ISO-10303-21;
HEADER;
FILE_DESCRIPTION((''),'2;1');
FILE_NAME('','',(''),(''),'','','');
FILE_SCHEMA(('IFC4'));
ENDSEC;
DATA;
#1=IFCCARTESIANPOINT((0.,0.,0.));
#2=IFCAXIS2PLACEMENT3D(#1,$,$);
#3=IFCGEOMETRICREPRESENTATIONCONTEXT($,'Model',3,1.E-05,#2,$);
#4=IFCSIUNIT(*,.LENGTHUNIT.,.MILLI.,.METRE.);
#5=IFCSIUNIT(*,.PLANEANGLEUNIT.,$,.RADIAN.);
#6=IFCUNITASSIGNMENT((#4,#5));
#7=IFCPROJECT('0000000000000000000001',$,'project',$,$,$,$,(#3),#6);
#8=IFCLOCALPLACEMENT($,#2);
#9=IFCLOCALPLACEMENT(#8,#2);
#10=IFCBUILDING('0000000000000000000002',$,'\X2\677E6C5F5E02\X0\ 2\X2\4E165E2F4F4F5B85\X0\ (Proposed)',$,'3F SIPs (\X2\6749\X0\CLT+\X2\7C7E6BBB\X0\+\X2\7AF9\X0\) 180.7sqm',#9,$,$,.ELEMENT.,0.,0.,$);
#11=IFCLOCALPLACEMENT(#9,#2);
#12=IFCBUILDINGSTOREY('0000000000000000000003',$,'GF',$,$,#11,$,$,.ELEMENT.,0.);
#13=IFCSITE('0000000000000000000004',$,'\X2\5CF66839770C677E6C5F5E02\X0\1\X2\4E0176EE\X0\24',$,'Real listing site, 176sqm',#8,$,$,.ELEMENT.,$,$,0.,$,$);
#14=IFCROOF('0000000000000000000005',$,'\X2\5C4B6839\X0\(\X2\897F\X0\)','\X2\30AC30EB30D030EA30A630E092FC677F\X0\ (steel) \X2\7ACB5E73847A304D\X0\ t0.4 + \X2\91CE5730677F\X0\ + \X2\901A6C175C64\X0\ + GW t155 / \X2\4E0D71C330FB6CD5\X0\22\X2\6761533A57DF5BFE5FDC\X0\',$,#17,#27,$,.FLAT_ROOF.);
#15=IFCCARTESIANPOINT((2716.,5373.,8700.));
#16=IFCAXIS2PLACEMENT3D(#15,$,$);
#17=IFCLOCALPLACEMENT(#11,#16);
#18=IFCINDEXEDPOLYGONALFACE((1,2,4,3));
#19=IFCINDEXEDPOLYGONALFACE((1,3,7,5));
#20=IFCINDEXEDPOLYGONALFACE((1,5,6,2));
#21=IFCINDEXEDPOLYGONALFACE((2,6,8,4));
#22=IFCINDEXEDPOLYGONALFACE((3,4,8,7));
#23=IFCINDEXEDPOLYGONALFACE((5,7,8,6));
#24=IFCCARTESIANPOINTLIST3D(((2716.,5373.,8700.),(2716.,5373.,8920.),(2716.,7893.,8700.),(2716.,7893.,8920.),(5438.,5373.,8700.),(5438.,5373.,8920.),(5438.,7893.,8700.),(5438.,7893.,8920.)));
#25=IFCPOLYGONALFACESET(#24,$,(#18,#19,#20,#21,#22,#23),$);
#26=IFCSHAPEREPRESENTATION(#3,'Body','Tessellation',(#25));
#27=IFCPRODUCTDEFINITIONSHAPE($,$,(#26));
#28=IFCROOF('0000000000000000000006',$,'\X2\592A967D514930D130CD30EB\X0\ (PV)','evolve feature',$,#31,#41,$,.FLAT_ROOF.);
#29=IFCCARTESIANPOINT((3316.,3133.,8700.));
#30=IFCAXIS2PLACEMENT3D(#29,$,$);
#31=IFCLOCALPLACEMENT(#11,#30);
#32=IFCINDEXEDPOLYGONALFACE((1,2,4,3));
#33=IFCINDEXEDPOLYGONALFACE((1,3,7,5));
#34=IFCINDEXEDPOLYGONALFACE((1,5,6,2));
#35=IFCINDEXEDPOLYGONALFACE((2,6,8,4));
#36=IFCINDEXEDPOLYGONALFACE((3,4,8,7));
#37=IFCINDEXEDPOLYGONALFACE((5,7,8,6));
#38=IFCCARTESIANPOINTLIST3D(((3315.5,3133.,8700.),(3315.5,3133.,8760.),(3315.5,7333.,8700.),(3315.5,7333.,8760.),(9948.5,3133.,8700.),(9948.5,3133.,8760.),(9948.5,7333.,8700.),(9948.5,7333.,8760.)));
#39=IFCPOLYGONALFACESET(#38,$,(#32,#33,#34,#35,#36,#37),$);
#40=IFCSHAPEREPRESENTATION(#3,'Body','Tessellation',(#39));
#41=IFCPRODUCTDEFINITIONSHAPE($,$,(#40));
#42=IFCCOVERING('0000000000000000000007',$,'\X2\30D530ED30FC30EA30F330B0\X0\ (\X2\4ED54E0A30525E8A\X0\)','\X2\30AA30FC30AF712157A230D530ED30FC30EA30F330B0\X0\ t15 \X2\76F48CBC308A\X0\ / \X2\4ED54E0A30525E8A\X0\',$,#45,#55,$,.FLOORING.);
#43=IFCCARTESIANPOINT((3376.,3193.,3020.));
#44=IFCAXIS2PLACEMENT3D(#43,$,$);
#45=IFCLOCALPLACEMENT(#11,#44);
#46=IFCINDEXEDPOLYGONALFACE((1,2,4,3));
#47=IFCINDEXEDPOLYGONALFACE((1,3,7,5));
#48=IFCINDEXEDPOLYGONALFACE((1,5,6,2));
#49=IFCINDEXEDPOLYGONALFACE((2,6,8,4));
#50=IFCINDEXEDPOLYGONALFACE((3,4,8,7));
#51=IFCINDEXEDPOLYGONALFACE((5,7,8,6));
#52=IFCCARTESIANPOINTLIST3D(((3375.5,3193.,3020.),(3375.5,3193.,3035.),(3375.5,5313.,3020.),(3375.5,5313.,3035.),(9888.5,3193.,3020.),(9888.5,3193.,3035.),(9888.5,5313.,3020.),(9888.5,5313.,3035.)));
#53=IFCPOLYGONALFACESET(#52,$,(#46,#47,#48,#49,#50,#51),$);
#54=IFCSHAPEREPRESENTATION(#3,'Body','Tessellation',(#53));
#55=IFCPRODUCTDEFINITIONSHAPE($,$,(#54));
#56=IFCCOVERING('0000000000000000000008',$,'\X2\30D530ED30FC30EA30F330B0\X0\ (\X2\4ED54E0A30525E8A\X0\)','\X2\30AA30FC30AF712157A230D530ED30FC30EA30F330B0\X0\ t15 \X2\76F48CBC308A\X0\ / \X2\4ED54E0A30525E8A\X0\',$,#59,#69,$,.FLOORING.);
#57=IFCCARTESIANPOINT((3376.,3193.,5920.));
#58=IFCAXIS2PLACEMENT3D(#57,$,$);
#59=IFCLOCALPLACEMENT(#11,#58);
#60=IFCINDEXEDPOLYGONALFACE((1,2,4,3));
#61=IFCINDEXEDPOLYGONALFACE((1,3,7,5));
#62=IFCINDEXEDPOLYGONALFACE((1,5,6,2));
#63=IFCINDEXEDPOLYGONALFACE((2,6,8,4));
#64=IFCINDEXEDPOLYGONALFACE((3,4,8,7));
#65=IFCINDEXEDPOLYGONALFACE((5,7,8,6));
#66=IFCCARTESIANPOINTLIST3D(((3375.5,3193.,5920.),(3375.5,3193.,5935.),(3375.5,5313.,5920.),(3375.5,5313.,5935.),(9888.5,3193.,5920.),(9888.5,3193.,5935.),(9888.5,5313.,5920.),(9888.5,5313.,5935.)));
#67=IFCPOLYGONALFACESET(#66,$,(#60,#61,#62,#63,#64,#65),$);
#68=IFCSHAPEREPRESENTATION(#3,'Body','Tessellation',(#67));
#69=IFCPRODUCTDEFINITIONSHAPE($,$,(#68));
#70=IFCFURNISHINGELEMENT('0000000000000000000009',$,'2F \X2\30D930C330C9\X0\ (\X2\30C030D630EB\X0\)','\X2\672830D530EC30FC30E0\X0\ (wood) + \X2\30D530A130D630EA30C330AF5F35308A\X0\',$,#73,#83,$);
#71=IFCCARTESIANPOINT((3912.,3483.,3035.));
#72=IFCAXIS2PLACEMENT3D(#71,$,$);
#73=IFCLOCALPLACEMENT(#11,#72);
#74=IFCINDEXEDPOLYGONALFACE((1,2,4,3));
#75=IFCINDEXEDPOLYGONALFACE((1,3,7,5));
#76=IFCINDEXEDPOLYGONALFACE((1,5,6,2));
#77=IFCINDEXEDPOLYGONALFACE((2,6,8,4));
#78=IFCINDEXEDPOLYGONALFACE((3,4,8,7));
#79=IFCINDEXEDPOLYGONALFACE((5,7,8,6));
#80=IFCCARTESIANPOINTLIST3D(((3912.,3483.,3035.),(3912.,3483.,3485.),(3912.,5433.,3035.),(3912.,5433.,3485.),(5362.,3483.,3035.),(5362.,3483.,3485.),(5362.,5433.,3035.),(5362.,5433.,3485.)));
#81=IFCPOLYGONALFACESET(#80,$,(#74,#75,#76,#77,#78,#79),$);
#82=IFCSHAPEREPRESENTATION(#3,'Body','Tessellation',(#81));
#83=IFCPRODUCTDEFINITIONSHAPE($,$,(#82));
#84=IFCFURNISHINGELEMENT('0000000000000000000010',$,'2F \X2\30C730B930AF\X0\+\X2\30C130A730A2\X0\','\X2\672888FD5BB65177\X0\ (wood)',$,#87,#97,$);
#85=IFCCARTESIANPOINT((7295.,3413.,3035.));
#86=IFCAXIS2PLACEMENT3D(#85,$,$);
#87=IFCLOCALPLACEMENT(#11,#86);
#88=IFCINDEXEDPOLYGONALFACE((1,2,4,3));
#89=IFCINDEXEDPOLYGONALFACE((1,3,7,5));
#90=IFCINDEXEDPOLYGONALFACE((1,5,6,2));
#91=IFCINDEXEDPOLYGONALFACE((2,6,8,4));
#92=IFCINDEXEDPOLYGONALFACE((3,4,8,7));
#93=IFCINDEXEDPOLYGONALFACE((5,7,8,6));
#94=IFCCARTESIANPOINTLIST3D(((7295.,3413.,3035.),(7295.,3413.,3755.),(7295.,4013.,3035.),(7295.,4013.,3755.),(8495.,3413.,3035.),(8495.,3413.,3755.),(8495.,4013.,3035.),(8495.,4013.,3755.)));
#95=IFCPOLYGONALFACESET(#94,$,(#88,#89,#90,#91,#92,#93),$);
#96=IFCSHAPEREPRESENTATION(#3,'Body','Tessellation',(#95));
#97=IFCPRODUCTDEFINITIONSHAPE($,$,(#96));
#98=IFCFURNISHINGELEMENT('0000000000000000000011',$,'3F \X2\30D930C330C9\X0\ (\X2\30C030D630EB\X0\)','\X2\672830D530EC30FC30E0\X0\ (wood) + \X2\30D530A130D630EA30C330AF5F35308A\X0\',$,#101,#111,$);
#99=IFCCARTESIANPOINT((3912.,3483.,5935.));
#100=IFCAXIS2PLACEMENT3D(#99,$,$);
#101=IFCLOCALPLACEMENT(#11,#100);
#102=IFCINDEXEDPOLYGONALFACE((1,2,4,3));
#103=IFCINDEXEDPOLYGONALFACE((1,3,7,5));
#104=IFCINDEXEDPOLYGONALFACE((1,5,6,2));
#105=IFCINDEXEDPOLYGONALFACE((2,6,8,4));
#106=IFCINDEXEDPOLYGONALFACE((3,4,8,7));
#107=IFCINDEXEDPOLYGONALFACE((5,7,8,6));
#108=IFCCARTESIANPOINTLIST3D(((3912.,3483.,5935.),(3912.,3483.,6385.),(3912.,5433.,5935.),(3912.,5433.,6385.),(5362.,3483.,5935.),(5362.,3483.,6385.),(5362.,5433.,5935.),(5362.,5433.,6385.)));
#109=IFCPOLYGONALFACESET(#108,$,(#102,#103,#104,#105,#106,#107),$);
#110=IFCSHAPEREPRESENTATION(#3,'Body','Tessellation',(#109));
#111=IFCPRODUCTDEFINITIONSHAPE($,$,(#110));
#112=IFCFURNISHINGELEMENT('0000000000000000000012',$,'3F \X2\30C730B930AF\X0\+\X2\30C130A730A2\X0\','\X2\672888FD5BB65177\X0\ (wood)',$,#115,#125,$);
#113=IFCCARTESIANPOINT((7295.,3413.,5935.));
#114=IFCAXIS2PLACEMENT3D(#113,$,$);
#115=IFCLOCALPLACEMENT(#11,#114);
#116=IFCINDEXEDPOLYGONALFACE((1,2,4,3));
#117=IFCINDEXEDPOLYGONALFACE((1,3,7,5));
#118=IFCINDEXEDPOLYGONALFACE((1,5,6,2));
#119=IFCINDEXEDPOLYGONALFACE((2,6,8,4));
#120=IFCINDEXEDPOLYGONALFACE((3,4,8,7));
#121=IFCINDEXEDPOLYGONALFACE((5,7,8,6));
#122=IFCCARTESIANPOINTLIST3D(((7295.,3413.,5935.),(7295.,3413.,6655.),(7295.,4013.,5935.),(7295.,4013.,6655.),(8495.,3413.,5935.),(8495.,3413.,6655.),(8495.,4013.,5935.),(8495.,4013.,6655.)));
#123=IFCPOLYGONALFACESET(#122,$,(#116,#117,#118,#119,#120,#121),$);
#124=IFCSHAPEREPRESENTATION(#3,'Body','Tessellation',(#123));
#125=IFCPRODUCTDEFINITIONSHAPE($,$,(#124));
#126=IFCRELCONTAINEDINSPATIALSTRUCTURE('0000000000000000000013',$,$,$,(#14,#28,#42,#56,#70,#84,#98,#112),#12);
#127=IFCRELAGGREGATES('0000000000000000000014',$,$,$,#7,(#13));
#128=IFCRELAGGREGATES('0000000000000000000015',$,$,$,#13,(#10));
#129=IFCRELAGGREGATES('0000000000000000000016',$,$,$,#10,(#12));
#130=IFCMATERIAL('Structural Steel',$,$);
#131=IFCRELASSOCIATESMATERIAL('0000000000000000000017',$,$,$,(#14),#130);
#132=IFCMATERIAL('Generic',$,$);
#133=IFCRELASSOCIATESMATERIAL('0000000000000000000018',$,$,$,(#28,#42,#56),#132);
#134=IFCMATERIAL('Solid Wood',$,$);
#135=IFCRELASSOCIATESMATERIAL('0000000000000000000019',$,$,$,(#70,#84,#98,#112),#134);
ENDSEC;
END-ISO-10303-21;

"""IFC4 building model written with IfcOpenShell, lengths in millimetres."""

from ifc_helpers import new_model, si_unit, frame, frame_2d, origin, place, context, project, spatial, rectangle, extrude, material, element, save


model = new_model("IFC4")

# Units and contexts
model_context = context("Model", 3, precision=1e-05, world=origin())
ifc_project = project(units=[si_unit("LENGTHUNIT", "METRE", prefix="MILLI"), si_unit("PLANEANGLEUNIT", "RADIAN")], contexts=[model_context])

# Site, building, storey
site_placement = place(None, origin())
site = spatial("IfcSite", under=ifc_project, at=site_placement, Name="島根県松江市1丁目24", ObjectType="Real listing site, 176sqm", CompositionType="ELEMENT", RefElevation=0.0)
building_placement = place(site_placement, origin())
building = spatial("IfcBuilding", under=site, at=building_placement, Name="松江市 2世帯住宅 (Proposed)", ObjectType="3F SIPs (杉CLT+籾殻+竹) 180.7sqm", CompositionType="ELEMENT", ElevationOfRefHeight=0.0, ElevationOfTerrain=0.0)
storey_placement = place(building_placement, origin())
storey = spatial("IfcBuildingStorey", under=building, at=storey_placement, Name="GF", CompositionType="ELEMENT", Elevation=0.0)

# Shared definitions
ifc_material_1 = material(Name="Solid Wood")

# Roofs
ifc_material_2 = material(Name="Structural Steel")
roof_1_placement = place(storey_placement, frame((2716.0, 5373.0, 8700.0)))
element("IfcRoof", 1, at=roof_1_placement, inside=storey, material=ifc_material_2, Name="屋根(西)", Description="ガルバリウム鋼板 (steel) 立平葺き t0.4 + 野地板 + 通気層 + GW t155 / 不燃・法22条区域対応", PredefinedType="FLAT_ROOF", context=model_context, shape_type="SweptSolid", body=[
    extrude(rectangle(XDim=2722.0, YDim=2520.0, at=frame_2d((1361.0, 1260.0))), frame((2716.0, 5373.0, 8700.0)), (0.0, 0.0, 1.0), 220.0),
])
ifc_material_3 = material(Name="Generic")
roof_2_placement = place(storey_placement, frame((3316.0, 3133.0, 8700.0)))
element("IfcRoof", 2, at=roof_2_placement, inside=storey, material=ifc_material_3, Name="太陽光パネル (PV)", Description="evolve feature", PredefinedType="FLAT_ROOF", context=model_context, shape_type="SweptSolid", body=[
    extrude(rectangle(XDim=6633.0, YDim=4200.0, at=frame_2d((3316.0, 2100.0))), frame((3316.0, 3133.0, 8700.0)), (0.0, 0.0, 1.0), 60.0),
])

# Coverings
covering_1_placement = place(storey_placement, frame((3376.0, 3193.0, 3020.0)))
element("IfcCovering", 3, at=covering_1_placement, inside=storey, material=ifc_material_3, Name="フローリング (仕上げ床)", Description="オーク無垢フローリング t15 直貼り / 仕上げ床", PredefinedType="FLOORING", context=model_context, shape_type="SweptSolid", body=[
    extrude(rectangle(XDim=6513.0, YDim=2120.0, at=frame_2d((3256.0, 1060.0))), frame((3376.0, 3193.0, 3020.0)), (0.0, 0.0, 1.0), 15.0),
])
covering_2_placement = place(storey_placement, frame((3376.0, 3193.0, 5920.0)))
element("IfcCovering", 4, at=covering_2_placement, inside=storey, material=ifc_material_3, Name="フローリング (仕上げ床)", Description="オーク無垢フローリング t15 直貼り / 仕上げ床", PredefinedType="FLOORING", context=model_context, shape_type="SweptSolid", body=[
    extrude(rectangle(XDim=6513.0, YDim=2120.0, at=frame_2d((3256.0, 1060.0))), frame((3376.0, 3193.0, 5920.0)), (0.0, 0.0, 1.0), 15.0),
])

# Furnishing elements
furnishing_1_placement = place(storey_placement, frame((3912.0, 3483.0, 3035.0)))
element("IfcFurnishingElement", 5, at=furnishing_1_placement, inside=storey, material=ifc_material_1, Name="2F ベッド (ダブル)", Description="木フレーム (wood) + ファブリック張り", context=model_context, shape_type="SweptSolid", body=[
    extrude(rectangle(XDim=1450.0, YDim=1950.0, at=frame_2d((725.0, 975.0))), frame((3912.0, 3483.0, 3035.0)), (0.0, 0.0, 1.0), 450.0),
])
furnishing_2_placement = place(storey_placement, frame((7295.0, 3413.0, 3035.0)))
element("IfcFurnishingElement", 6, at=furnishing_2_placement, inside=storey, material=ifc_material_1, Name="2F デスク+チェア", Description="木製家具 (wood)", context=model_context, shape_type="SweptSolid", body=[
    extrude(rectangle(XDim=1200.0, YDim=600.0, at=frame_2d((600.0, 300.0))), frame((7295.0, 3413.0, 3035.0)), (0.0, 0.0, 1.0), 720.0),
])
furnishing_3_placement = place(storey_placement, frame((3912.0, 3483.0, 5935.0)))
element("IfcFurnishingElement", 7, at=furnishing_3_placement, inside=storey, material=ifc_material_1, Name="3F ベッド (ダブル)", Description="木フレーム (wood) + ファブリック張り", context=model_context, shape_type="SweptSolid", body=[
    extrude(rectangle(XDim=1450.0, YDim=1950.0, at=frame_2d((725.0, 975.0))), frame((3912.0, 3483.0, 5935.0)), (0.0, 0.0, 1.0), 450.0),
])
furnishing_4_placement = place(storey_placement, frame((7295.0, 3413.0, 5935.0)))
element("IfcFurnishingElement", 8, at=furnishing_4_placement, inside=storey, material=ifc_material_1, Name="3F デスク+チェア", Description="木製家具 (wood)", context=model_context, shape_type="SweptSolid", body=[
    extrude(rectangle(XDim=1200.0, YDim=600.0, at=frame_2d((600.0, 300.0))), frame((7295.0, 3413.0, 5935.0)), (0.0, 0.0, 1.0), 720.0),
])

save(model, "model.ifc")
